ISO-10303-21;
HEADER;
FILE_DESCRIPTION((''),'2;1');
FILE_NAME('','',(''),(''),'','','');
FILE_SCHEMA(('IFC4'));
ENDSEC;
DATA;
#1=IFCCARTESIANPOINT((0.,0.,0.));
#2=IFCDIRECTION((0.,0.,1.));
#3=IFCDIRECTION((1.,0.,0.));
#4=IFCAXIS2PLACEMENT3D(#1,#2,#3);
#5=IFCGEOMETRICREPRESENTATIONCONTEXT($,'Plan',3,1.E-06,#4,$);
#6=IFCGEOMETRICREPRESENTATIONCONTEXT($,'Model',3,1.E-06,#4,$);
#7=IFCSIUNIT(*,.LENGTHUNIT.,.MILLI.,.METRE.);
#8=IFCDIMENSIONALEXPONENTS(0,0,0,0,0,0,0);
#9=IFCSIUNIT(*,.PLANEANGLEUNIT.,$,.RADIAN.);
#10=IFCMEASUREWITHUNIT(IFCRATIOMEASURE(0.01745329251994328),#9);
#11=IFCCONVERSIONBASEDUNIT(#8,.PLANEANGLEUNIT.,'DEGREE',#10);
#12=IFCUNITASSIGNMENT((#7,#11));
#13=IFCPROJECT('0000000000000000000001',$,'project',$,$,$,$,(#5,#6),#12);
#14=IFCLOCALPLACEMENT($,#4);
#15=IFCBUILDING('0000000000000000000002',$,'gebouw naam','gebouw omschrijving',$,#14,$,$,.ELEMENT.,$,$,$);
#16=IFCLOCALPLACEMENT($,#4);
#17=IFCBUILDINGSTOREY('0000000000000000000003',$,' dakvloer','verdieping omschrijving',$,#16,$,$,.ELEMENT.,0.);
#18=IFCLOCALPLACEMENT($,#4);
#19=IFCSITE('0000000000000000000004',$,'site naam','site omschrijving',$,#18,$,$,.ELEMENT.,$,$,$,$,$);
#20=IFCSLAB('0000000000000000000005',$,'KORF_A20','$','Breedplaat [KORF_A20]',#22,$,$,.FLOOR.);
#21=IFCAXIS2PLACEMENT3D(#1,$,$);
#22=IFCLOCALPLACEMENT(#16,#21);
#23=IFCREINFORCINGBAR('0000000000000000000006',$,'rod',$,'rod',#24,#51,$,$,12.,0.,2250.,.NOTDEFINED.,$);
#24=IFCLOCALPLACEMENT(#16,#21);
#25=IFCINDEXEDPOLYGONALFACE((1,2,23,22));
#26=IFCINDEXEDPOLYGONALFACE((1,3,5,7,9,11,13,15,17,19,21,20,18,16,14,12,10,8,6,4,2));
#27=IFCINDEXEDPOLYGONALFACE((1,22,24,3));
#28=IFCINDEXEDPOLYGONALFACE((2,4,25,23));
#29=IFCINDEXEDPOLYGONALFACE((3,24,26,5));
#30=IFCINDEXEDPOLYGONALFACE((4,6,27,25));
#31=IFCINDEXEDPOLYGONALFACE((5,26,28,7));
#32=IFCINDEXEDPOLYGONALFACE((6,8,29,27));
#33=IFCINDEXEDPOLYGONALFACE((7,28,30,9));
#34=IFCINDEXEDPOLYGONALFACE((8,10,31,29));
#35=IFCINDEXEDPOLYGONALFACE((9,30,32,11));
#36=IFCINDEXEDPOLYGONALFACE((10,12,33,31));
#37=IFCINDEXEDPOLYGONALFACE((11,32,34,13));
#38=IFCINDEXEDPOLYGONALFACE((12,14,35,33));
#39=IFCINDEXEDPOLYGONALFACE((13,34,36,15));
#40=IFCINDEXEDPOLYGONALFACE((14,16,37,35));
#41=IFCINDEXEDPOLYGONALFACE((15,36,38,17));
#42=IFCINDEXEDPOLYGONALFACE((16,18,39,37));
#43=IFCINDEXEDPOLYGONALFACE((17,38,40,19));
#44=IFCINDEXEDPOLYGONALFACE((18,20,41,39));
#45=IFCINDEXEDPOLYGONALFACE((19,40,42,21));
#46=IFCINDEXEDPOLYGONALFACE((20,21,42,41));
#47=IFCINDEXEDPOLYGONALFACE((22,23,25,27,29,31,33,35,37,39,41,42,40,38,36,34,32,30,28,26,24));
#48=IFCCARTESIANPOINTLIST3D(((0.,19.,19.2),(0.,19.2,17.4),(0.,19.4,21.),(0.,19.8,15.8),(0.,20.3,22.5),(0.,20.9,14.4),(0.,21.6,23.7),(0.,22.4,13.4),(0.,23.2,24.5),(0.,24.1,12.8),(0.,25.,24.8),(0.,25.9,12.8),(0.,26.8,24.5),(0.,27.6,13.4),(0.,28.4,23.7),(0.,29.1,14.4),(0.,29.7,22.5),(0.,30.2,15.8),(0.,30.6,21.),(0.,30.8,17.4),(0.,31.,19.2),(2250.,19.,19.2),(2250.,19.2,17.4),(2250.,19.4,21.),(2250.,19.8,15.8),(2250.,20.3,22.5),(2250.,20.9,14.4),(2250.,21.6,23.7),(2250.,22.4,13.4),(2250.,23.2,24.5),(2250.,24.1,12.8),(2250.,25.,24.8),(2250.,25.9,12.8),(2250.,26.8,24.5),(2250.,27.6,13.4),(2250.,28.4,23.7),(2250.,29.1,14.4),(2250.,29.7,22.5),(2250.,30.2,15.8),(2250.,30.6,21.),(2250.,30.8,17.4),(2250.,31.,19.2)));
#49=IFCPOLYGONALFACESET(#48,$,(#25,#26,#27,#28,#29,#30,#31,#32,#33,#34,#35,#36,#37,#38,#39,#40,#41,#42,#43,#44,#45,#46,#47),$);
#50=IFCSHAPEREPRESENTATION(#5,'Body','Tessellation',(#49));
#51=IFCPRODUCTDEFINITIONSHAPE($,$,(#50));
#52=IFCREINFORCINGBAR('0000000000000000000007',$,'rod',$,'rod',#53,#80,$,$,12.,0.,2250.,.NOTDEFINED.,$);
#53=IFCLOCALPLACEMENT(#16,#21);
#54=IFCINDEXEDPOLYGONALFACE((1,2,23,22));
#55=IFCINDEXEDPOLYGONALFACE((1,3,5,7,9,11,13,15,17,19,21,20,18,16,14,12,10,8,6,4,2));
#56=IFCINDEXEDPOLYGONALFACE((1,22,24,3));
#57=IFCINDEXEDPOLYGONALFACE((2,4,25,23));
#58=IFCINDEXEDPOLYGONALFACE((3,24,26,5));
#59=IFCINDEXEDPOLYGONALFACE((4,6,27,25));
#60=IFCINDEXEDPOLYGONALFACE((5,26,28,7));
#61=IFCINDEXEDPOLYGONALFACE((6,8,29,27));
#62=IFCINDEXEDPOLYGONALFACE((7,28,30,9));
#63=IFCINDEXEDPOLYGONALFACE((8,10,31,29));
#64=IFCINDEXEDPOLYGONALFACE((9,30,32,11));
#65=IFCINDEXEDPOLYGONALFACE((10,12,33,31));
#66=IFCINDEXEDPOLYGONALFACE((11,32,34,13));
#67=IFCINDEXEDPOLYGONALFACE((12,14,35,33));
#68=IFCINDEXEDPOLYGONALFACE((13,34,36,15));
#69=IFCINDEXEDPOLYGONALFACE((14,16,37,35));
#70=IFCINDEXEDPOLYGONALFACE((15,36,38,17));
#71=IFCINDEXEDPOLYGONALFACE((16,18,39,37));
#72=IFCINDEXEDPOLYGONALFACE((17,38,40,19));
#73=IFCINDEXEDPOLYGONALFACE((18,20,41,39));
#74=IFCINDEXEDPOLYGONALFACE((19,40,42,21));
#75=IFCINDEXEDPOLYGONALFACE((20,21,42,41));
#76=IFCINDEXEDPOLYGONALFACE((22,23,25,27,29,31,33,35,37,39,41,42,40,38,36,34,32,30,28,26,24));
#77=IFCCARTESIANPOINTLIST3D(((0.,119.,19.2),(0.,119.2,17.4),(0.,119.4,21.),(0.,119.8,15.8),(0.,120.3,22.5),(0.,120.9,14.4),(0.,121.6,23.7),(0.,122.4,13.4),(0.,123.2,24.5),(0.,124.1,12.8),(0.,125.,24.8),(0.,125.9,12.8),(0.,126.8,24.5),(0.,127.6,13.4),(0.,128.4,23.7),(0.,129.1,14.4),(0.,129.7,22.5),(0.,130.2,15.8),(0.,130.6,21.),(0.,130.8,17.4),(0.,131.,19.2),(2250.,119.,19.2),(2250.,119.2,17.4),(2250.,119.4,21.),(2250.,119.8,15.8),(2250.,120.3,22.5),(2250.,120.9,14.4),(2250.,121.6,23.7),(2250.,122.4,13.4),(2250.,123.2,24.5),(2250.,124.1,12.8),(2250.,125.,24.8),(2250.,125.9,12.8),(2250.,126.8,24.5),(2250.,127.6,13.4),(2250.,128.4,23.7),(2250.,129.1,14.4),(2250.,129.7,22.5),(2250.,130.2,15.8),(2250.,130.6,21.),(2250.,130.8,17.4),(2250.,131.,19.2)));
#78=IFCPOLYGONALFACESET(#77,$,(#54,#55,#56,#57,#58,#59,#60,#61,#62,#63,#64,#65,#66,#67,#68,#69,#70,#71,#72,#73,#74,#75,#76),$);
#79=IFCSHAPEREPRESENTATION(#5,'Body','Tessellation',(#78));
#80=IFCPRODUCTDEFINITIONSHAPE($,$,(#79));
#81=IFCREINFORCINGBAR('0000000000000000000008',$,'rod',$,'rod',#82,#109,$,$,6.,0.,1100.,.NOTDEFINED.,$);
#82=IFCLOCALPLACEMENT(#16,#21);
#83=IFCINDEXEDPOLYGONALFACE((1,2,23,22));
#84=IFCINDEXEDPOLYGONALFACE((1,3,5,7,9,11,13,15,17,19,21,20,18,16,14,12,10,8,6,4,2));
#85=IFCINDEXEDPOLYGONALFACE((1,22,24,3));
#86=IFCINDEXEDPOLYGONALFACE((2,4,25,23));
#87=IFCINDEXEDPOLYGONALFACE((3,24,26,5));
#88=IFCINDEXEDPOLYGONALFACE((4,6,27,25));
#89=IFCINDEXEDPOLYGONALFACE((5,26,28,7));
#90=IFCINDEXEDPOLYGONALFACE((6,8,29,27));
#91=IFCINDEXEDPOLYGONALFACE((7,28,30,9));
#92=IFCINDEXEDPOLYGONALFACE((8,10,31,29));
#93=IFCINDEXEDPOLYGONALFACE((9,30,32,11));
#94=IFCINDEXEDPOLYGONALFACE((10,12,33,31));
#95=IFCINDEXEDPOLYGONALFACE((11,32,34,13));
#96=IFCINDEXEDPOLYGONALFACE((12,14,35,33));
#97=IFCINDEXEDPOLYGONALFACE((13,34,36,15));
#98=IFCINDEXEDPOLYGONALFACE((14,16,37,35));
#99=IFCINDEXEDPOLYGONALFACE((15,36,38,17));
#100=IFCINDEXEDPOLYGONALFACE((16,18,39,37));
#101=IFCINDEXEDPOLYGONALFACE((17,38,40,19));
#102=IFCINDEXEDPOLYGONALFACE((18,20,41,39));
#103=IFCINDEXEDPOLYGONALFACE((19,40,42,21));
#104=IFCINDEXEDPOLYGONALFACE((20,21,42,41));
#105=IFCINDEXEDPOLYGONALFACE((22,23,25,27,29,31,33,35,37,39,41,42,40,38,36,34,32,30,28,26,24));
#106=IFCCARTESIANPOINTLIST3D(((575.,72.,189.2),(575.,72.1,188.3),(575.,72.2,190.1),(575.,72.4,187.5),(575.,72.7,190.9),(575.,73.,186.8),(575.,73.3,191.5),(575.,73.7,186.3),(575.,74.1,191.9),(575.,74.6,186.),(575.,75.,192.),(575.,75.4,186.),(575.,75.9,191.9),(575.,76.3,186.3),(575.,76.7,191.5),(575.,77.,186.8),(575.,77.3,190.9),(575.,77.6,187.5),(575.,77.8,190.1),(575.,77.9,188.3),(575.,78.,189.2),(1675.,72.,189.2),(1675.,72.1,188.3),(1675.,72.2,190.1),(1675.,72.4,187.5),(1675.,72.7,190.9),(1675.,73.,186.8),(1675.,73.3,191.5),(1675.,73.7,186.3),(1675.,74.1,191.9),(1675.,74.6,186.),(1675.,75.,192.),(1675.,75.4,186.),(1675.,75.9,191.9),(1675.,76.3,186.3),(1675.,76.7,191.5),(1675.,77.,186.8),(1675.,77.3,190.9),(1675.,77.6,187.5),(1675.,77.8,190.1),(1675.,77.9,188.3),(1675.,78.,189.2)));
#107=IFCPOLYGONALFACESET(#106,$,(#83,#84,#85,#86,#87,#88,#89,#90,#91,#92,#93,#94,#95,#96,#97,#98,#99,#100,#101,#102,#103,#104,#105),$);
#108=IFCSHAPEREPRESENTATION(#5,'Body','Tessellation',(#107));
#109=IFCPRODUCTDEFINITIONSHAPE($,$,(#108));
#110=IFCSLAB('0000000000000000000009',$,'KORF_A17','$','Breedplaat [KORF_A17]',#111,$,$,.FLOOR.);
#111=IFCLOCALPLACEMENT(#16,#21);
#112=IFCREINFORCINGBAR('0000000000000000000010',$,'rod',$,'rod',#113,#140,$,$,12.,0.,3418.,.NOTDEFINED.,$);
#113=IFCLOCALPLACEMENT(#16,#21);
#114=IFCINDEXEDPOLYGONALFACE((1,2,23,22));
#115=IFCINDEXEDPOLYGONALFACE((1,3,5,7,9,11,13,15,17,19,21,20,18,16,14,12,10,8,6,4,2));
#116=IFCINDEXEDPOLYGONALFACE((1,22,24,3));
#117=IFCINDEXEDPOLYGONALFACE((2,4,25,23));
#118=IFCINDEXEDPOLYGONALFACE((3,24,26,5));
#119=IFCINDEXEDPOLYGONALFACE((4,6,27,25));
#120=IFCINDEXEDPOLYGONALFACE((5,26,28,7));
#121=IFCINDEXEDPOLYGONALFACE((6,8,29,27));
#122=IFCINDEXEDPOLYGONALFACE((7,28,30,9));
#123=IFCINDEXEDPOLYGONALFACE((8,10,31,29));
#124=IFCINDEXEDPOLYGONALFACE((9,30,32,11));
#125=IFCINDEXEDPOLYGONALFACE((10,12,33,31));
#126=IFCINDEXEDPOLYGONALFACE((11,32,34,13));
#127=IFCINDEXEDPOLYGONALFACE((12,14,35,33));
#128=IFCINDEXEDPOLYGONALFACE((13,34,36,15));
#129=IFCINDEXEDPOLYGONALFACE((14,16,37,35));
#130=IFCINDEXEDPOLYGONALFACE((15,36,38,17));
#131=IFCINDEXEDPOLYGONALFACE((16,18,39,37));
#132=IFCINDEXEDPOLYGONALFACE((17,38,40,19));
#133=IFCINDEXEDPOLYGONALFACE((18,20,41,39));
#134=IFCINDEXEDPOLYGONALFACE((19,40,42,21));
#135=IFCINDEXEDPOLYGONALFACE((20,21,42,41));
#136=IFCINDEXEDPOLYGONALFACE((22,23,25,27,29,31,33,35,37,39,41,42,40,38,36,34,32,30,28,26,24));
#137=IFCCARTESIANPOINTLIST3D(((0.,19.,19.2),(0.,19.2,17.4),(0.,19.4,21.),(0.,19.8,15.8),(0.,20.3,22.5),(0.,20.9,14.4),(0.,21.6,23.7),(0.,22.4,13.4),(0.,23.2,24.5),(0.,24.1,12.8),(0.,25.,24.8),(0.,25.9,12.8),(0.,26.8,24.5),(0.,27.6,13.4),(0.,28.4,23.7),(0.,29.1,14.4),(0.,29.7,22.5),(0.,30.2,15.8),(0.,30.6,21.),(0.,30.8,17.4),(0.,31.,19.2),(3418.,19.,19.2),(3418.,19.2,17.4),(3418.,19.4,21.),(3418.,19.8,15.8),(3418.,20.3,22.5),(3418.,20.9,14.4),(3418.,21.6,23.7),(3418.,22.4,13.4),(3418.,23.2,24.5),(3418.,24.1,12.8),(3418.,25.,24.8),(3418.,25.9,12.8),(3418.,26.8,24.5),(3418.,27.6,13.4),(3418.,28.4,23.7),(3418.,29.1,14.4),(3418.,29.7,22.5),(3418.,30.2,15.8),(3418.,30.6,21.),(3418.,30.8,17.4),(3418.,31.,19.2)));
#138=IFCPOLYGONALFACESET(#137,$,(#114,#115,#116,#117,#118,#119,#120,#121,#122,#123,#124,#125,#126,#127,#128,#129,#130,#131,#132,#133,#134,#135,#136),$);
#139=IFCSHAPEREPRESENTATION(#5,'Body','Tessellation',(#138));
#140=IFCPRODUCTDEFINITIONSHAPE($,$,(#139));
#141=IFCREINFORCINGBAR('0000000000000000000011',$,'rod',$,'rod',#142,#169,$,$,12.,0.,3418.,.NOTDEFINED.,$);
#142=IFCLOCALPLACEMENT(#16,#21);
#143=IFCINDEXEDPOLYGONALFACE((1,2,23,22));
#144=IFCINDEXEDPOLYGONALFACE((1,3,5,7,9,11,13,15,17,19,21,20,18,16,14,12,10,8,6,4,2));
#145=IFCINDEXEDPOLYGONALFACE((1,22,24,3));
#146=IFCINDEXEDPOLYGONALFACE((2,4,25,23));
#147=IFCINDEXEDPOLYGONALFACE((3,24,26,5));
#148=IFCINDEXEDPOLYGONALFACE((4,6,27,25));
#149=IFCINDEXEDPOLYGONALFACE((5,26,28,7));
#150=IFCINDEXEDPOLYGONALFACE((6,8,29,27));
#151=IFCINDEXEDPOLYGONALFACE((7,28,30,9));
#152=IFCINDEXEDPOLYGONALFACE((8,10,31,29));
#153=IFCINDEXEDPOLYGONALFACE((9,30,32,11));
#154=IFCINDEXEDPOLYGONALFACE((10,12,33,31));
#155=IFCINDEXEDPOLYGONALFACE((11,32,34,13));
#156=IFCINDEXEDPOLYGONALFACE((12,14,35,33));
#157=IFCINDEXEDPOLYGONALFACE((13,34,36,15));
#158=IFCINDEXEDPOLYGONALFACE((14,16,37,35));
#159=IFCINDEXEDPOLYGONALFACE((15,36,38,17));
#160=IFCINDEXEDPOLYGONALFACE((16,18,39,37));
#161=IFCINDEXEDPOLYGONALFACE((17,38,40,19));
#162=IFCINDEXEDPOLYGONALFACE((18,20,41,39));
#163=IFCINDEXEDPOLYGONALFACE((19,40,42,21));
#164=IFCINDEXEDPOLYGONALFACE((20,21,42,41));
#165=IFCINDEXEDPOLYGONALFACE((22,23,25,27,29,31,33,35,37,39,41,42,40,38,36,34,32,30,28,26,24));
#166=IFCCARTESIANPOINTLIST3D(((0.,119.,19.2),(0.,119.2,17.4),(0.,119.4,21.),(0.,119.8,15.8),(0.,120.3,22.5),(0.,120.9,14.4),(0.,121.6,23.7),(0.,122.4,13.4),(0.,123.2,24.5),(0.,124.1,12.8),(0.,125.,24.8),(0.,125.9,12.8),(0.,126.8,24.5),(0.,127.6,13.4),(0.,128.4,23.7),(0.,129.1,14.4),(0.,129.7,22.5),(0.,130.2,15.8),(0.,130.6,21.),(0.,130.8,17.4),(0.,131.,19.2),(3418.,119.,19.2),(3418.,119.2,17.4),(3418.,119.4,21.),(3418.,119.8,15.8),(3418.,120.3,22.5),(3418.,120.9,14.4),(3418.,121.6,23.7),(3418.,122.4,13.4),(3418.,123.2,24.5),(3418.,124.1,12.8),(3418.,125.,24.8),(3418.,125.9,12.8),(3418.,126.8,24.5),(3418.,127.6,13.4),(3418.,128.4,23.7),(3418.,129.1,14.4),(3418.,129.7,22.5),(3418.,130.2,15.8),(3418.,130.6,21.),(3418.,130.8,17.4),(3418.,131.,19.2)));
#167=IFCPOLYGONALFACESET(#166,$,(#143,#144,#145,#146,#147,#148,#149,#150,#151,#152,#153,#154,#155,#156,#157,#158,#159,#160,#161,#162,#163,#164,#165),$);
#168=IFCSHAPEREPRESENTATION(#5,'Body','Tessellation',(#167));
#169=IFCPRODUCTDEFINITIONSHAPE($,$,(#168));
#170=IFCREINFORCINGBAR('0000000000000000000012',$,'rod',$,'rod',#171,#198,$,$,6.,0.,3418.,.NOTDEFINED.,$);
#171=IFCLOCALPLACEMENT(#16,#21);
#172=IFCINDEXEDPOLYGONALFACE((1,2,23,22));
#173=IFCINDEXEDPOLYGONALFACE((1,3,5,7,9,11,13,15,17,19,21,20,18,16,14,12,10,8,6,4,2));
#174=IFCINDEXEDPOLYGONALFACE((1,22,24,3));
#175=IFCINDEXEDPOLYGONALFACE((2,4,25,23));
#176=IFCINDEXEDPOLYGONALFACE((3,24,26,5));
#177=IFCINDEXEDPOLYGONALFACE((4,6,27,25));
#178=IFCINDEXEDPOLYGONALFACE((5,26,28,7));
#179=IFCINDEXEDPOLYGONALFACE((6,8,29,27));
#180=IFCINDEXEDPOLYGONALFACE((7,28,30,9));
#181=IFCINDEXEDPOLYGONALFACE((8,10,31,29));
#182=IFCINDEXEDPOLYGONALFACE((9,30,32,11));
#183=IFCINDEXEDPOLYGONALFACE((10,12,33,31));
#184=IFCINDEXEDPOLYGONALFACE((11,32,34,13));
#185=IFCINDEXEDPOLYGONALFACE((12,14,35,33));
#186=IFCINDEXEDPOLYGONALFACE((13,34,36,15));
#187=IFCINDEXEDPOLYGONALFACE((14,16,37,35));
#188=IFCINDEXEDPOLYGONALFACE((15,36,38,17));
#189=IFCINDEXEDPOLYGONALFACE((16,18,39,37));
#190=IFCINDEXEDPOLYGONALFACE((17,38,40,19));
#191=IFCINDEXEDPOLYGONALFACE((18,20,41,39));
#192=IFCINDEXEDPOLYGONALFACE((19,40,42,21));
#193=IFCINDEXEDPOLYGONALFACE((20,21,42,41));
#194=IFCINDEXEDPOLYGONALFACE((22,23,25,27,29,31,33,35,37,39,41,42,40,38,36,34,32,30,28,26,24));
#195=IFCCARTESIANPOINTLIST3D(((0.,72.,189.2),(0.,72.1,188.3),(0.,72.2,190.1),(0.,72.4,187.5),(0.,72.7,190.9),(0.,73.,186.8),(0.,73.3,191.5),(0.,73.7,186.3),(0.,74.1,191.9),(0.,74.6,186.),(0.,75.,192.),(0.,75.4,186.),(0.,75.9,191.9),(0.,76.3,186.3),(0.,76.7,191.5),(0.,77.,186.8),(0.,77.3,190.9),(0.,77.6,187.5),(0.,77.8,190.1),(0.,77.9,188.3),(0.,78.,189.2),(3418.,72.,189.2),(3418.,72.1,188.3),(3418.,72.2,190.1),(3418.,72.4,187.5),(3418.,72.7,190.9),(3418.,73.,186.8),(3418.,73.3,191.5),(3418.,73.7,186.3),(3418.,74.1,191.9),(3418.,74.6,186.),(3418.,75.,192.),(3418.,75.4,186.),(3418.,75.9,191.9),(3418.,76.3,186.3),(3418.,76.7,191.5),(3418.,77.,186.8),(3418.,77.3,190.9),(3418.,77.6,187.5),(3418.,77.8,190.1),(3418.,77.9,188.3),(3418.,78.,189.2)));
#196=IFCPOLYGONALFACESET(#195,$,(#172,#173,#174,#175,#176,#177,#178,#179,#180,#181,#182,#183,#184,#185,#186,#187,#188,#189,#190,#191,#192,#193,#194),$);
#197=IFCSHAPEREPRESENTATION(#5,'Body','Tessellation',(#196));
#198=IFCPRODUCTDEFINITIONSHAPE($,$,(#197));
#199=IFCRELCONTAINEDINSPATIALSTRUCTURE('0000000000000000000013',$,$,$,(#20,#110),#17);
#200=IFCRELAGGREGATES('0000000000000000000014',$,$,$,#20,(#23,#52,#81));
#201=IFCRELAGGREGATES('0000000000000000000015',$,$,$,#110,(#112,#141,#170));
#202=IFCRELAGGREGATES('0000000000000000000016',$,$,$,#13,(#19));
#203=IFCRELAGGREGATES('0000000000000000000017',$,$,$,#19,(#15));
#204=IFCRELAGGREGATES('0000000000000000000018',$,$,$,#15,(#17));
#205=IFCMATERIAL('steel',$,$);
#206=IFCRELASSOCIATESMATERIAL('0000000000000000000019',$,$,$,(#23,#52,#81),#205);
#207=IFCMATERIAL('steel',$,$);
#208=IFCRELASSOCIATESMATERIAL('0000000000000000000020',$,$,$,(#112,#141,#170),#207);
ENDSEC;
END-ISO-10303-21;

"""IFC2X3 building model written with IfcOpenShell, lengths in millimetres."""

from ifc_helpers import new_model, entity, si_unit, converted_unit, frame, origin_with_axes, origin_2d_with_axis, place, context, project, spatial, circle, extrude, material, element, aggregate, save


model = new_model("IFC2X3")

# Units and contexts
plan_context = context("Plan", 3, precision=1e-06, world=origin_with_axes())
model_context = context("Model", 3, precision=1e-06, world=origin_with_axes())
ifc_project = project(units=[si_unit("LENGTHUNIT", "METRE", prefix="MILLI"), converted_unit("PLANEANGLEUNIT", "DEGREE", entity("IfcRatioMeasure", 0.01745329251994328), si_unit("PLANEANGLEUNIT", "RADIAN"), dimensions=[0, 0, 0, 0, 0, 0, 0])], contexts=[plan_context, model_context])

# Site, building, storey
site_placement = place(None, origin_with_axes())
site = spatial("IfcSite", under=ifc_project, at=site_placement, Name="site naam", Description="site omschrijving", CompositionType="ELEMENT")
building_placement = place(None, origin_with_axes())
building = spatial("IfcBuilding", under=site, at=building_placement, Name="gebouw naam", Description="gebouw omschrijving", CompositionType="ELEMENT")
storey_placement = place(None, origin_with_axes())
storey = spatial("IfcBuildingStorey", under=building, at=storey_placement, Name=" dakvloer", Description="verdieping omschrijving", CompositionType="ELEMENT", Elevation=0.0)

# Slabs, reinforcing bars
slab_1_placement = place(None, origin_with_axes())
slab_1 = element("IfcSlab", 1, at=slab_1_placement, inside=storey, Name="KORF_A20", Description="$", ObjectType="Breedplaat [KORF_A20]", PredefinedType="FLOOR")
ifc_material_1 = material(Name="steel")
reinforcing_bar_1_placement = place(slab_1_placement, frame((0.0, 25.0, 18.8), z_axis=(0.0, 0.0, 1.0), x_axis=(1.0, 0.0, 0.0)))
reinforcing_bar_1 = element("IfcReinforcingBar", 2, at=reinforcing_bar_1_placement, material=ifc_material_1, Name="rod", ObjectType="rod", BarLength=2250.0, BarRole="NOTDEFINED", CrossSectionArea=0.0, NominalDiameter=12.0, context=plan_context, shape_type="SweptSolid", body=[
    extrude(circle(Radius=6.0, at=origin_2d_with_axis()), frame((0.0, 0.0, 0.0), z_axis=(1.0, 0.0, 0.0), x_axis=(0.0, 0.0, 1.0)), (0.0, 0.0, 1.0), 2250.0),
])
reinforcing_bar_2_placement = place(slab_1_placement, frame((0.0, 125.0, 18.8), z_axis=(0.0, 0.0, 1.0), x_axis=(1.0, 0.0, 0.0)))
reinforcing_bar_2 = element("IfcReinforcingBar", 3, at=reinforcing_bar_2_placement, material=ifc_material_1, Name="rod", ObjectType="rod", BarLength=2250.0, BarRole="NOTDEFINED", CrossSectionArea=0.0, NominalDiameter=12.0, context=plan_context, shape_type="SweptSolid", body=[
    extrude(circle(Radius=6.0, at=origin_2d_with_axis()), frame((0.0, 0.0, 0.0), z_axis=(1.0, 0.0, 0.0), x_axis=(0.0, 0.0, 1.0)), (0.0, 0.0, 1.0), 2250.0),
])
reinforcing_bar_3_placement = place(slab_1_placement, frame((575.0, 75.0, 189.0), z_axis=(0.0, 0.0, 1.0), x_axis=(1.0, 0.0, 0.0)))
reinforcing_bar_3 = element("IfcReinforcingBar", 4, at=reinforcing_bar_3_placement, material=ifc_material_1, Name="rod", ObjectType="rod", BarLength=1100.0, BarRole="NOTDEFINED", CrossSectionArea=0.0, NominalDiameter=6.0, context=plan_context, shape_type="SweptSolid", body=[
    extrude(circle(Radius=3.0, at=origin_2d_with_axis()), frame((0.0, 0.0, 0.0), z_axis=(1.0, 0.0, 0.0), x_axis=(0.0, 0.0, 1.0)), (0.0, 0.0, 1.0), 1100.0),
])
aggregate(slab_1, [reinforcing_bar_1, reinforcing_bar_2, reinforcing_bar_3])
slab_2_placement = place(None, origin_with_axes())
slab_2 = element("IfcSlab", 5, at=slab_2_placement, inside=storey, Name="KORF_A17", Description="$", ObjectType="Breedplaat [KORF_A17]", PredefinedType="FLOOR")
ifc_material_2 = material(Name="steel")
reinforcing_bar_4_placement = place(slab_2_placement, frame((0.0, 25.0, 18.8), z_axis=(0.0, 0.0, 1.0), x_axis=(1.0, 0.0, 0.0)))
reinforcing_bar_4 = element("IfcReinforcingBar", 6, at=reinforcing_bar_4_placement, material=ifc_material_2, Name="rod", ObjectType="rod", BarLength=3418.0, BarRole="NOTDEFINED", CrossSectionArea=0.0, NominalDiameter=12.0, context=plan_context, shape_type="SweptSolid", body=[
    extrude(circle(Radius=6.0, at=origin_2d_with_axis()), frame((0.0, 0.0, 0.0), z_axis=(1.0, 0.0, 0.0), x_axis=(0.0, 0.0, 1.0)), (0.0, 0.0, 1.0), 3418.0),
])
reinforcing_bar_5_placement = place(slab_2_placement, frame((0.0, 125.0, 18.8), z_axis=(0.0, 0.0, 1.0), x_axis=(1.0, 0.0, 0.0)))
reinforcing_bar_5 = element("IfcReinforcingBar", 7, at=reinforcing_bar_5_placement, material=ifc_material_2, Name="rod", ObjectType="rod", BarLength=3418.0, BarRole="NOTDEFINED", CrossSectionArea=0.0, NominalDiameter=12.0, context=plan_context, shape_type="SweptSolid", body=[
    extrude(circle(Radius=6.0, at=origin_2d_with_axis()), frame((0.0, 0.0, 0.0), z_axis=(1.0, 0.0, 0.0), x_axis=(0.0, 0.0, 1.0)), (0.0, 0.0, 1.0), 3418.0),
])
reinforcing_bar_6_placement = place(slab_2_placement, frame((0.0, 75.0, 189.0), z_axis=(0.0, 0.0, 1.0), x_axis=(1.0, 0.0, 0.0)))
reinforcing_bar_6 = element("IfcReinforcingBar", 8, at=reinforcing_bar_6_placement, material=ifc_material_2, Name="rod", ObjectType="rod", BarLength=3418.0, BarRole="NOTDEFINED", CrossSectionArea=0.0, NominalDiameter=6.0, context=plan_context, shape_type="SweptSolid", body=[
    extrude(circle(Radius=3.0, at=origin_2d_with_axis()), frame((0.0, 0.0, 0.0), z_axis=(1.0, 0.0, 0.0), x_axis=(0.0, 0.0, 1.0)), (0.0, 0.0, 1.0), 3418.0),
])
aggregate(slab_2, [reinforcing_bar_4, reinforcing_bar_5, reinforcing_bar_6])

save(model, "model.ifc")
